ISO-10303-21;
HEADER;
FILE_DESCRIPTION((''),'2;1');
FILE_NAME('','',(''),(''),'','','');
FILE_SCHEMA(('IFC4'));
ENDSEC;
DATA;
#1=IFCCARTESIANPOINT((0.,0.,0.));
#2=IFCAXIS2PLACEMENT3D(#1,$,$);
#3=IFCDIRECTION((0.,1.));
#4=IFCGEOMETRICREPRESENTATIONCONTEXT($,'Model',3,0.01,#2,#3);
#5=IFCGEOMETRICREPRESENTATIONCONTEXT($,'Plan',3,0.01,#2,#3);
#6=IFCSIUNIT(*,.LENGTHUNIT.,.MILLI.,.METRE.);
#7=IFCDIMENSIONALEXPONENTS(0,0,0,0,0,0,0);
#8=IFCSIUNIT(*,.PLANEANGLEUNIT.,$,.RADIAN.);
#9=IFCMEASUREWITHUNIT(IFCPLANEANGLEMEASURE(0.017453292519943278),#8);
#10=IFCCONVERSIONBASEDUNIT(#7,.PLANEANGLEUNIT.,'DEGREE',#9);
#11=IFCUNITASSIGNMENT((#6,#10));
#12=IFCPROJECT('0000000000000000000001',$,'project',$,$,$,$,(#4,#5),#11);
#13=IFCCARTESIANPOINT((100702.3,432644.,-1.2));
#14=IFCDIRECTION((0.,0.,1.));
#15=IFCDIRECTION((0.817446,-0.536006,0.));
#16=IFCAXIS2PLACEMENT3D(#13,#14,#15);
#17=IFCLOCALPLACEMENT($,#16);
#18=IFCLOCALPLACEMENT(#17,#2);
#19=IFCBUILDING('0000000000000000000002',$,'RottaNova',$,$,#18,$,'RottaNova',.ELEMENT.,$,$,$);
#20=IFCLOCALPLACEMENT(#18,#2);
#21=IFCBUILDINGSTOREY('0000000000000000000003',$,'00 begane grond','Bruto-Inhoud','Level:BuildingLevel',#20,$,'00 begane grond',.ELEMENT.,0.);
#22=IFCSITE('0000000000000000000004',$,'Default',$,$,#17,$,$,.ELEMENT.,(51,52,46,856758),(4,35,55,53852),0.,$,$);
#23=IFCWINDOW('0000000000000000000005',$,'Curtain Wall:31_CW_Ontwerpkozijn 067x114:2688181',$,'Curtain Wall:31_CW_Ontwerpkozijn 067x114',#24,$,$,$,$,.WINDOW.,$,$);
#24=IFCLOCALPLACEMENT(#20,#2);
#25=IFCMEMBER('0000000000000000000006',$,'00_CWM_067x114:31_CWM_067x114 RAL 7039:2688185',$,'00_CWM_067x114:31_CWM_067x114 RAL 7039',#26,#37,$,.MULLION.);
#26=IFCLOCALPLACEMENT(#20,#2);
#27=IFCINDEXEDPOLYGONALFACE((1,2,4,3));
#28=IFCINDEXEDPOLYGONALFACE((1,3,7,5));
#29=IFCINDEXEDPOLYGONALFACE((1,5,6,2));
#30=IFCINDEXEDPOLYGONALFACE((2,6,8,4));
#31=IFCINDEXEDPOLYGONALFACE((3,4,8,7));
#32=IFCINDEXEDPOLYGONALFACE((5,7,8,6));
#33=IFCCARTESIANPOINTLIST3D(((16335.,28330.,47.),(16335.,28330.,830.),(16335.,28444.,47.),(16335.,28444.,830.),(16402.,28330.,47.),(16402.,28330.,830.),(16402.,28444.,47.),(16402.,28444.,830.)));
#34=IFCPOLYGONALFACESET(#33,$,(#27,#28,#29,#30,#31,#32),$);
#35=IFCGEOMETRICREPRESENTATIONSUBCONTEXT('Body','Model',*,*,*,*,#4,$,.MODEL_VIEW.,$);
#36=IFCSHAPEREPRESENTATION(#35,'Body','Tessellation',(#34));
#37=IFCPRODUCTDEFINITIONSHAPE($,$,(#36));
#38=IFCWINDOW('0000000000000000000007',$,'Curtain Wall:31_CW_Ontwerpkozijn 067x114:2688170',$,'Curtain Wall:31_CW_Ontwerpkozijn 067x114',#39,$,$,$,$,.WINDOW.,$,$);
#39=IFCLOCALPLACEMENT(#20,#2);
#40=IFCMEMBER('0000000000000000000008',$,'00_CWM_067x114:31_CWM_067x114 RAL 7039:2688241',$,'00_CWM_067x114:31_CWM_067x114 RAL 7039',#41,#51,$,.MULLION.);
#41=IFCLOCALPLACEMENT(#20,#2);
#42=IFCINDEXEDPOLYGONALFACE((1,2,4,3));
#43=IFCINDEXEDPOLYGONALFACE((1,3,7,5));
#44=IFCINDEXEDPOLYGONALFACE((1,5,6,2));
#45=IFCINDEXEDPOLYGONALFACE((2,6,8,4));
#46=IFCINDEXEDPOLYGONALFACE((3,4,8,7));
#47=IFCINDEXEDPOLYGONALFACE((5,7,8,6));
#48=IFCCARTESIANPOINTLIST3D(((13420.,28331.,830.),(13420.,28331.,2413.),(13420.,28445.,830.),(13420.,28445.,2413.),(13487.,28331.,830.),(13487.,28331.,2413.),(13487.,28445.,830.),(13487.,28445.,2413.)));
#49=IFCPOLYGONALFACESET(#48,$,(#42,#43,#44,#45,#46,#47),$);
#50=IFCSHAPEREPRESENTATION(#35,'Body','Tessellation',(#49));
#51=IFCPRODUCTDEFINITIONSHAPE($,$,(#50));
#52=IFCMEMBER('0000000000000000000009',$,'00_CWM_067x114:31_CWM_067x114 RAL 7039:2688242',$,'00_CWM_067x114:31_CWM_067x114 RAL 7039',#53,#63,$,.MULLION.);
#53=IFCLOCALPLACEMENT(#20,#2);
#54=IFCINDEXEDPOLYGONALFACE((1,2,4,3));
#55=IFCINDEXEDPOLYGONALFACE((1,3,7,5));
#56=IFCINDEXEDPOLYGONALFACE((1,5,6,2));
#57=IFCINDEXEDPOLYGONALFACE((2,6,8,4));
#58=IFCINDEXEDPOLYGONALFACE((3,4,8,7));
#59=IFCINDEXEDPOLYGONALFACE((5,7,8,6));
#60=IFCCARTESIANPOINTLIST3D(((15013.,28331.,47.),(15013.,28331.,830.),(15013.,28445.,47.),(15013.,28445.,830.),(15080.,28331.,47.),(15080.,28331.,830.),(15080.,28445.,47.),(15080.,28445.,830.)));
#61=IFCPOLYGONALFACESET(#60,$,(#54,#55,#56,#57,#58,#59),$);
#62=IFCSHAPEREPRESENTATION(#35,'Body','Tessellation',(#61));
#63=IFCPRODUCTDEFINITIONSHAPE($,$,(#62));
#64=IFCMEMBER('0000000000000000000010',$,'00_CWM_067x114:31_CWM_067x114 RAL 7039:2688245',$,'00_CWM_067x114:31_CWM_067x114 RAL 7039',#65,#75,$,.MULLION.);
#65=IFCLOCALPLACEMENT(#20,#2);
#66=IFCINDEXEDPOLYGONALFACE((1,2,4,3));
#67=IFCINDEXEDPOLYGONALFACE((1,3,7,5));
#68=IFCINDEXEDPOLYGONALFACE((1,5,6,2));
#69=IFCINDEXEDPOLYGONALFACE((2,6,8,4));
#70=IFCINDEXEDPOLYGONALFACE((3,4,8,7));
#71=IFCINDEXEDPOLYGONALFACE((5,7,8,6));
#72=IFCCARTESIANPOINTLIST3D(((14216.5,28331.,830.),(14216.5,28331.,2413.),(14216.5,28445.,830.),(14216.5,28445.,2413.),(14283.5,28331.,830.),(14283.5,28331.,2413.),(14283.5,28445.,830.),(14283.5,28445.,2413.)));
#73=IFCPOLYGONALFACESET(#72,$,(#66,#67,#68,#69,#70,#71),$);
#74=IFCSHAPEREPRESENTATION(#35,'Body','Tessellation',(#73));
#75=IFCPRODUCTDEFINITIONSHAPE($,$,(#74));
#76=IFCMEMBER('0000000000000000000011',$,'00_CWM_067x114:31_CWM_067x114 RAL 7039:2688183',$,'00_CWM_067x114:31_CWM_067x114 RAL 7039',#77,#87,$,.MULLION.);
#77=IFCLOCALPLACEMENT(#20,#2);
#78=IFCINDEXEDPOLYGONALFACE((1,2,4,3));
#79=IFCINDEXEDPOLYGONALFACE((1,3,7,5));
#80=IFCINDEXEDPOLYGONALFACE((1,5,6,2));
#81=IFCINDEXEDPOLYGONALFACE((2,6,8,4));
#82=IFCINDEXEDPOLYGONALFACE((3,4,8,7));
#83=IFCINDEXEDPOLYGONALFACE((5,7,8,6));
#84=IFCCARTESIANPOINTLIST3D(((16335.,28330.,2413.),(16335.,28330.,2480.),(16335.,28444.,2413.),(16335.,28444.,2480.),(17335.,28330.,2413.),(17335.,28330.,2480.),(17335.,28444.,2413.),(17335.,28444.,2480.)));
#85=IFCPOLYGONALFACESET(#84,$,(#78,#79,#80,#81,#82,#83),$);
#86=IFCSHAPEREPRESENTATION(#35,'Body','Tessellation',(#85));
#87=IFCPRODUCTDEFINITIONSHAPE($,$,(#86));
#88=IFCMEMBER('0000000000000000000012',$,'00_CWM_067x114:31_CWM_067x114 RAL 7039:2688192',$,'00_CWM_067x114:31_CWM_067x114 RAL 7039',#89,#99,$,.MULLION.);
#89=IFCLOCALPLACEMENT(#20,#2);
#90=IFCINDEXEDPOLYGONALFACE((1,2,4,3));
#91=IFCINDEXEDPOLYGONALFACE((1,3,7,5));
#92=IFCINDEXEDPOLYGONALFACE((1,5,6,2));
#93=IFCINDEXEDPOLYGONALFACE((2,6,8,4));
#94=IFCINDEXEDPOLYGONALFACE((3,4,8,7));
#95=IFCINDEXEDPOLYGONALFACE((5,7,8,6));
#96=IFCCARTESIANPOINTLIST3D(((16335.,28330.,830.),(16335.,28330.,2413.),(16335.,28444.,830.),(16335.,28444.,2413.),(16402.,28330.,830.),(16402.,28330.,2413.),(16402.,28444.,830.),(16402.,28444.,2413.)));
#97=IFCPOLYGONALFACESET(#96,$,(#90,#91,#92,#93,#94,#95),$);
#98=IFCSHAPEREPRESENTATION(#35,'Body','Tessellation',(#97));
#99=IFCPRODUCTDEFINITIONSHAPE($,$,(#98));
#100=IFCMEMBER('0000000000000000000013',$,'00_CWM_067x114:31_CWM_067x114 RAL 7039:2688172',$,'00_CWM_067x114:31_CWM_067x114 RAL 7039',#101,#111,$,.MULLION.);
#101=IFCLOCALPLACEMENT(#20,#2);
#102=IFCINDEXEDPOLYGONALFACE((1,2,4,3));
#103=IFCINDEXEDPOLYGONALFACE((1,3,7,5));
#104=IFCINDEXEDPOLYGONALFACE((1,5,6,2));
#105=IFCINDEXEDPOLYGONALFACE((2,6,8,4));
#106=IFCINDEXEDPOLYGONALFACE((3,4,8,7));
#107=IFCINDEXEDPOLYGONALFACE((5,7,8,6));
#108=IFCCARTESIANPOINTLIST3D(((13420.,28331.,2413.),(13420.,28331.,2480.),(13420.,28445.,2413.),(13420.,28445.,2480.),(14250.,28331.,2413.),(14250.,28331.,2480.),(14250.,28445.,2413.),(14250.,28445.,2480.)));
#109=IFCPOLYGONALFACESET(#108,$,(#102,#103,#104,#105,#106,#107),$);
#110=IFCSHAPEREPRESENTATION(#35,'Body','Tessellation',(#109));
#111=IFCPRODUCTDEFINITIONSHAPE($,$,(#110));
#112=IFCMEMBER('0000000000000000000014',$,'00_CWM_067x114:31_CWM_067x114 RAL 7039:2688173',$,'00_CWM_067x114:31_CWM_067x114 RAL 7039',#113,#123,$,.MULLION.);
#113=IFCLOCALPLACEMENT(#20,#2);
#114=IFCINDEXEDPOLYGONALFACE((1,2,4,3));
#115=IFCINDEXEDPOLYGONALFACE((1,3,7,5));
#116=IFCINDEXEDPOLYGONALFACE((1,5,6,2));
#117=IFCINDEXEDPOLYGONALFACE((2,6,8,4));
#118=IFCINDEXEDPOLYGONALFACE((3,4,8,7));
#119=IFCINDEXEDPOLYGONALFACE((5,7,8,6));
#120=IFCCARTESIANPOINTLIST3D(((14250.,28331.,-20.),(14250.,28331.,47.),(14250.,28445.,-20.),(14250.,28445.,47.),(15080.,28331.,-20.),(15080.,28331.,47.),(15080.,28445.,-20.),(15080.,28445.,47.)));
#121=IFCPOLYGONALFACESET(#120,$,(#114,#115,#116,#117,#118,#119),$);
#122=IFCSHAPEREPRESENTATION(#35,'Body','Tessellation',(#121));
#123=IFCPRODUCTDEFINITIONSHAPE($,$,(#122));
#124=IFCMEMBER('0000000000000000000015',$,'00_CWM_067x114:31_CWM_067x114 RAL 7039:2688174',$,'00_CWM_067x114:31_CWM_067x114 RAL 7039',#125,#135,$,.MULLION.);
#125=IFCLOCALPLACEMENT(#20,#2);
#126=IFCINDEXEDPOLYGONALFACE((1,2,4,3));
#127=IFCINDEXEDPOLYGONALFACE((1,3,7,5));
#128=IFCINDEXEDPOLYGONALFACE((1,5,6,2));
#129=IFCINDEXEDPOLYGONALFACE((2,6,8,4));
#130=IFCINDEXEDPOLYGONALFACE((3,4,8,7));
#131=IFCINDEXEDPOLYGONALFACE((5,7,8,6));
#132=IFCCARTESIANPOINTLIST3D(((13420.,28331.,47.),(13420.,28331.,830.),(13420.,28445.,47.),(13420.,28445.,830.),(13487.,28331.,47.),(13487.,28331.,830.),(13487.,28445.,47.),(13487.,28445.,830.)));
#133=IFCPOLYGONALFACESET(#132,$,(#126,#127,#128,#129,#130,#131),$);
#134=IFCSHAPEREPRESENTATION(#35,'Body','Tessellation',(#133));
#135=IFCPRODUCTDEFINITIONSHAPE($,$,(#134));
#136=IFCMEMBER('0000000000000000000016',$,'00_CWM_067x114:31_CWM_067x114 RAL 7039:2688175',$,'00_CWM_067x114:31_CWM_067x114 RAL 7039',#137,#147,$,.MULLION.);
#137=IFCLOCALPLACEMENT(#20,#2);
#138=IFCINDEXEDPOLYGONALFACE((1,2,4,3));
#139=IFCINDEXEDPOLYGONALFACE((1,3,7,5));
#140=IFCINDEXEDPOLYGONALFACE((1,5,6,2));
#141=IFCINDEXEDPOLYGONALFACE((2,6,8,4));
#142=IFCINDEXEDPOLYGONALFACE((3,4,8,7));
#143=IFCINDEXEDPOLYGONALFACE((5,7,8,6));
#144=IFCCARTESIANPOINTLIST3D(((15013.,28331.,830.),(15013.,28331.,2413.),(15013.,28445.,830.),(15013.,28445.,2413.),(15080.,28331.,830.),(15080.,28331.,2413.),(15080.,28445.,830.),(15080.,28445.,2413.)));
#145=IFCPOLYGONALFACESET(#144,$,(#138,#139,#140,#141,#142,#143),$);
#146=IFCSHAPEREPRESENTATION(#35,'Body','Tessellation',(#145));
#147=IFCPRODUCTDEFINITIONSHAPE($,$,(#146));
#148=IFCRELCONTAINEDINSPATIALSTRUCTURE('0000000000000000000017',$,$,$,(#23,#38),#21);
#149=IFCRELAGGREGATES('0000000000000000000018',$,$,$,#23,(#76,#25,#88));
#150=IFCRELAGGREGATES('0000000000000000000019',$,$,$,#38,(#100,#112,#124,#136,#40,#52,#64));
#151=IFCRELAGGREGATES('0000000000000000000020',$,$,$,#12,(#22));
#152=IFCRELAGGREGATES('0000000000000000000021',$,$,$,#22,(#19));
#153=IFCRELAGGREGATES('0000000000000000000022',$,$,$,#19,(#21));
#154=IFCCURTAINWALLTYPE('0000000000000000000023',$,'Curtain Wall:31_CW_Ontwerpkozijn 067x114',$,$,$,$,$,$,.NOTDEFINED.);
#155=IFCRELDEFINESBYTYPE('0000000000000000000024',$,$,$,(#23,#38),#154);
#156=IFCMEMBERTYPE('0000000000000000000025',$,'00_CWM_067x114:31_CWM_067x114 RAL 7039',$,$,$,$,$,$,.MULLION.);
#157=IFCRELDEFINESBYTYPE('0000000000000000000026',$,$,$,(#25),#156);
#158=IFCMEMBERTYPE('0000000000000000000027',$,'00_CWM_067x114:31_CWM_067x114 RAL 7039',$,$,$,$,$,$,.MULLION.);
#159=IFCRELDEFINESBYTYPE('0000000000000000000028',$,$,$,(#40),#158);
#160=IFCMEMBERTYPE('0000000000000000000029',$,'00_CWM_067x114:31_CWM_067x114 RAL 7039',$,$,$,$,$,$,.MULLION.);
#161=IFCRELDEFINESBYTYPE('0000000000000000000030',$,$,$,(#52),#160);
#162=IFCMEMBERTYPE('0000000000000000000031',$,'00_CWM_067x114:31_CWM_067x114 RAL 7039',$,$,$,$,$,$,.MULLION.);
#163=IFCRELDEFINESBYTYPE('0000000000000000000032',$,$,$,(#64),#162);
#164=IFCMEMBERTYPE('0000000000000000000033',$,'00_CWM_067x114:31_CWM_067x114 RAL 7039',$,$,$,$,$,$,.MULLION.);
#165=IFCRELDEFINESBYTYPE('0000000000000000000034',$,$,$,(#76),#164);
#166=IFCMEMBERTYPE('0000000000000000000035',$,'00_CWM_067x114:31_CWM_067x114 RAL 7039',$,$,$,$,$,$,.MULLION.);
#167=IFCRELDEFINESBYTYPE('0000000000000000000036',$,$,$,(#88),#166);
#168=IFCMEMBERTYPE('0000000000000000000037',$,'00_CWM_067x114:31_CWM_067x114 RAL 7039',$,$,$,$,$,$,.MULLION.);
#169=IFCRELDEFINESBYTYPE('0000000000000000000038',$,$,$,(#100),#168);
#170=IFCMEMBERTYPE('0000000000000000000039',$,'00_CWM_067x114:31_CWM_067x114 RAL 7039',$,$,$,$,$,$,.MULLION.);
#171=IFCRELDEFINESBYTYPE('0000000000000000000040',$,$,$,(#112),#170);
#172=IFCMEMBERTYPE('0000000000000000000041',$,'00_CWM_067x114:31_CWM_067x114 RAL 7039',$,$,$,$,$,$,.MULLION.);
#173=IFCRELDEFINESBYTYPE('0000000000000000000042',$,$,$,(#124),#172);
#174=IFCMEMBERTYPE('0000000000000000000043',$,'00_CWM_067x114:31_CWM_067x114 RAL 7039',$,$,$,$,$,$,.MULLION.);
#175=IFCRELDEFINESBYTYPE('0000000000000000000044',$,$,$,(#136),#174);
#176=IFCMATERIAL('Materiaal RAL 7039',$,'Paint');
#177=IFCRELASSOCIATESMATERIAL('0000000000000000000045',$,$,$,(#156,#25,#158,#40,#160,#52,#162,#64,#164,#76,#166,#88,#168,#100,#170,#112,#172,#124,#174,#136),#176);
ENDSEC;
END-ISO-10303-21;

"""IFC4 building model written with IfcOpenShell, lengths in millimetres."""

from ifc_helpers import new_model, entity, si_unit, converted_unit, direction, frame, origin, place, context, subcontext, project, spatial, indexed_curve, outline, extrude, source, transform, mapped, material, type_object, type_shapes, element, aggregate, save


model = new_model("IFC4")

# Units and contexts
model_context = context("Model", 3, precision=0.01, world=origin(), true_north=direction((0.0, 1.0)))
plan_context = context("Plan", 3, precision=0.01, world=origin(), true_north=direction((0.0, 1.0)))
body_context = subcontext(model_context, "Body", "Model", "MODEL_VIEW")
ifc_project = project(units=[si_unit("LENGTHUNIT", "METRE", prefix="MILLI"), converted_unit("PLANEANGLEUNIT", "DEGREE", entity("IfcPlaneAngleMeasure", 0.017453292519943278), si_unit("PLANEANGLEUNIT", "RADIAN"), dimensions=[0, 0, 0, 0, 0, 0, 0])], contexts=[model_context, plan_context])

# Site, building, storey
site_placement = place(None, frame((100702.3, 432644.0, -1.2), z_axis=(0.0, 0.0, 1.0), x_axis=(0.817446, -0.536006, 0.0)))
site = spatial("IfcSite", under=ifc_project, at=site_placement, Name="Default", CompositionType="ELEMENT", RefLatitude=(51, 52, 46, 856758), RefLongitude=(4, 35, 55, 53852), RefElevation=0.0)
building_placement = place(site_placement, origin())
building = spatial("IfcBuilding", under=site, at=building_placement, Name="RottaNova", LongName="RottaNova", CompositionType="ELEMENT")
storey_placement = place(building_placement, origin())
storey = spatial("IfcBuildingStorey", under=building, at=storey_placement, Name="00 begane grond", Description="Bruto-Inhoud", ObjectType="Level:BuildingLevel", LongName="00 begane grond", CompositionType="ELEMENT", Elevation=0.0)

# Window, member
curtain_wall_type = type_object("IfcCurtainWallType", Name="Curtain Wall:31_CW_Ontwerpkozijn 067x114", PredefinedType="NOTDEFINED")
window_1_placement = place(storey_placement, origin())
window_1 = element("IfcWindow", 1, at=window_1_placement, inside=storey, type_object=curtain_wall_type, Name="Curtain Wall:31_CW_Ontwerpkozijn 067x114:2688181", ObjectType="Curtain Wall:31_CW_Ontwerpkozijn 067x114", PredefinedType="WINDOW")
ifc_material_1 = material(Name="Materiaal RAL 7039", Category="Paint")
member_type_1 = type_object("IfcMemberType", Name="00_CWM_067x114:31_CWM_067x114 RAL 7039", PredefinedType="MULLION", material=ifc_material_1)
shared_shape_1 = source(origin(), body_context, "Body", "SweptSolid", [
    extrude(outline(indexed_curve([(-33.5, -57.0), (33.5, -57.0), (33.5, 57.0), (-33.5, 57.0), (-33.5, -57.0)], self_intersect=False)), frame((-33.5, 57.0, -783.0), z_axis=(0.0, 0.0, 1.0), x_axis=(-1.0, 0.0, 0.0)), (0.0, 0.0, 1.0), 783.0),
])
type_shapes(member_type_1, [shared_shape_1])
member_1_placement = place(window_1_placement, frame((16335.0, 28330.0, 47.0), z_axis=(0.0, 0.0, -1.0), x_axis=(-1.0, 0.0, 0.0)))
member_1 = element("IfcMember", 2, at=member_1_placement, type_object=member_type_1, material=ifc_material_1, Name="00_CWM_067x114:31_CWM_067x114 RAL 7039:2688185", ObjectType="00_CWM_067x114:31_CWM_067x114 RAL 7039", PredefinedType="MULLION", context=body_context, shape_type="MappedRepresentation", body=[
    mapped(shared_shape_1, transform((0.0, 0.0, 0.0), scale=1.0)),
])

# Window, members
window_2_placement = place(storey_placement, origin())
window_2 = element("IfcWindow", 3, at=window_2_placement, inside=storey, type_object=curtain_wall_type, Name="Curtain Wall:31_CW_Ontwerpkozijn 067x114:2688170", ObjectType="Curtain Wall:31_CW_Ontwerpkozijn 067x114", PredefinedType="WINDOW")
member_type_2 = type_object("IfcMemberType", Name="00_CWM_067x114:31_CWM_067x114 RAL 7039", PredefinedType="MULLION", material=ifc_material_1)
shared_shape_2 = source(origin(), body_context, "Body", "SweptSolid", [
    extrude(outline(indexed_curve([(-33.5, -57.0), (33.5, -57.0), (33.5, 57.0), (-33.5, 57.0), (-33.5, -57.0)], self_intersect=False)), frame((-33.5, 57.0, -1583.0), z_axis=(0.0, 0.0, 1.0), x_axis=(-1.0, 0.0, 0.0)), (0.0, 0.0, 1.0), 1583.0),
])
type_shapes(member_type_2, [shared_shape_2])
member_2_placement = place(window_2_placement, frame((13420.0, 28331.0, 830.0), z_axis=(0.0, 0.0, -1.0), x_axis=(-1.0, 0.0, 0.0)))
member_2 = element("IfcMember", 4, at=member_2_placement, type_object=member_type_2, material=ifc_material_1, Name="00_CWM_067x114:31_CWM_067x114 RAL 7039:2688241", ObjectType="00_CWM_067x114:31_CWM_067x114 RAL 7039", PredefinedType="MULLION", context=body_context, shape_type="MappedRepresentation", body=[
    mapped(shared_shape_2, transform((0.0, 0.0, 0.0), scale=1.0)),
])
member_type_3 = type_object("IfcMemberType", Name="00_CWM_067x114:31_CWM_067x114 RAL 7039", PredefinedType="MULLION", material=ifc_material_1)
shared_shape_3 = source(origin(), body_context, "Body", "SweptSolid", [
    extrude(outline(indexed_curve([(-33.5, -57.0), (33.5, -57.0), (33.5, 57.0), (-33.5, 57.0), (-33.5, -57.0)], self_intersect=False)), frame((-33.5, 57.0, -783.0), z_axis=(0.0, 0.0, 1.0), x_axis=(-1.0, 0.0, 0.0)), (0.0, 0.0, 1.0), 783.0),
])
type_shapes(member_type_3, [shared_shape_3])
member_3_placement = place(window_2_placement, frame((15080.0, 28331.0, 830.0)))
member_3 = element("IfcMember", 5, at=member_3_placement, type_object=member_type_3, material=ifc_material_1, Name="00_CWM_067x114:31_CWM_067x114 RAL 7039:2688242", ObjectType="00_CWM_067x114:31_CWM_067x114 RAL 7039", PredefinedType="MULLION", context=body_context, shape_type="MappedRepresentation", body=[
    mapped(shared_shape_3, transform((0.0, 0.0, 0.0), scale=1.0)),
])
member_type_4 = type_object("IfcMemberType", Name="00_CWM_067x114:31_CWM_067x114 RAL 7039", PredefinedType="MULLION", material=ifc_material_1)
shared_shape_4 = source(origin(), body_context, "Body", "SweptSolid", [
    extrude(outline(indexed_curve([(-33.5, -57.0), (33.5, -57.0), (33.5, 57.0), (-33.5, 57.0), (-33.5, -57.0)], self_intersect=False)), frame((0.0, 57.0, -1583.0), z_axis=(0.0, 0.0, 1.0), x_axis=(-1.0, 0.0, 0.0)), (0.0, 0.0, 1.0), 1583.0),
])
type_shapes(member_type_4, [shared_shape_4])
member_4_placement = place(window_2_placement, frame((14250.0, 28331.0, 830.0), z_axis=(0.0, 0.0, -1.0), x_axis=(-1.0, 0.0, 0.0)))
member_4 = element("IfcMember", 6, at=member_4_placement, type_object=member_type_4, material=ifc_material_1, Name="00_CWM_067x114:31_CWM_067x114 RAL 7039:2688245", ObjectType="00_CWM_067x114:31_CWM_067x114 RAL 7039", PredefinedType="MULLION", context=body_context, shape_type="MappedRepresentation", body=[
    mapped(shared_shape_4, transform((0.0, 0.0, 0.0), scale=1.0)),
])

# Members
member_type_5 = type_object("IfcMemberType", Name="00_CWM_067x114:31_CWM_067x114 RAL 7039", PredefinedType="MULLION", material=ifc_material_1)
shared_shape_5 = source(origin(), body_context, "Body", "SweptSolid", [
    extrude(outline(indexed_curve([(-33.5, -57.0), (33.5, -57.0), (33.5, 57.0), (-33.5, 57.0), (-33.5, -57.0)], self_intersect=False)), frame((-33.5, 57.0, -1000.0), z_axis=(0.0, 0.0, 1.0), x_axis=(-1.0, 0.0, 0.0)), (0.0, 0.0, 1.0), 1000.0),
])
type_shapes(member_type_5, [shared_shape_5])
member_5_placement = place(window_1_placement, frame((16335.0, 28330.0, 2480.0), z_axis=(-1.0, 0.0, 0.0), x_axis=(0.0, 0.0, 1.0)))
member_5 = element("IfcMember", 7, at=member_5_placement, type_object=member_type_5, material=ifc_material_1, Name="00_CWM_067x114:31_CWM_067x114 RAL 7039:2688183", ObjectType="00_CWM_067x114:31_CWM_067x114 RAL 7039", PredefinedType="MULLION", context=body_context, shape_type="MappedRepresentation", body=[
    mapped(shared_shape_5, transform((0.0, 0.0, 0.0), scale=1.0)),
])
member_type_6 = type_object("IfcMemberType", Name="00_CWM_067x114:31_CWM_067x114 RAL 7039", PredefinedType="MULLION", material=ifc_material_1)
shared_shape_6 = source(origin(), body_context, "Body", "SweptSolid", [
    extrude(outline(indexed_curve([(-33.5, -57.0), (33.5, -57.0), (33.5, 57.0), (-33.5, 57.0), (-33.5, -57.0)], self_intersect=False)), frame((-33.5, 57.0, -1583.0), z_axis=(0.0, 0.0, 1.0), x_axis=(-1.0, 0.0, 0.0)), (0.0, 0.0, 1.0), 1583.0),
])
type_shapes(member_type_6, [shared_shape_6])
member_6_placement = place(window_1_placement, frame((16335.0, 28330.0, 830.0), z_axis=(0.0, 0.0, -1.0), x_axis=(-1.0, 0.0, 0.0)))
member_6 = element("IfcMember", 8, at=member_6_placement, type_object=member_type_6, material=ifc_material_1, Name="00_CWM_067x114:31_CWM_067x114 RAL 7039:2688192", ObjectType="00_CWM_067x114:31_CWM_067x114 RAL 7039", PredefinedType="MULLION", context=body_context, shape_type="MappedRepresentation", body=[
    mapped(shared_shape_6, transform((0.0, 0.0, 0.0), scale=1.0)),
])
aggregate(window_1, [member_5, member_1, member_6])
member_type_7 = type_object("IfcMemberType", Name="00_CWM_067x114:31_CWM_067x114 RAL 7039", PredefinedType="MULLION", material=ifc_material_1)
shared_shape_7 = source(origin(), body_context, "Body", "SweptSolid", [
    extrude(outline(indexed_curve([(-33.5, -57.0), (33.5, -57.0), (33.5, 57.0), (-33.5, 57.0), (-33.5, -57.0)], self_intersect=False)), frame((-33.5, 57.0, -830.0), z_axis=(0.0, 0.0, 1.0), x_axis=(-1.0, 0.0, 0.0)), (0.0, 0.0, 1.0), 830.0),
])
type_shapes(member_type_7, [shared_shape_7])
member_7_placement = place(window_2_placement, frame((13420.0, 28331.0, 2480.0), z_axis=(-1.0, 0.0, 0.0), x_axis=(0.0, 0.0, 1.0)))
member_7 = element("IfcMember", 9, at=member_7_placement, type_object=member_type_7, material=ifc_material_1, Name="00_CWM_067x114:31_CWM_067x114 RAL 7039:2688172", ObjectType="00_CWM_067x114:31_CWM_067x114 RAL 7039", PredefinedType="MULLION", context=body_context, shape_type="MappedRepresentation", body=[
    mapped(shared_shape_7, transform((0.0, 0.0, 0.0), scale=1.0)),
])
member_type_8 = type_object("IfcMemberType", Name="00_CWM_067x114:31_CWM_067x114 RAL 7039", PredefinedType="MULLION", material=ifc_material_1)
shared_shape_8 = source(origin(), body_context, "Body", "SweptSolid", [
    extrude(outline(indexed_curve([(-33.5, -57.0), (33.5, -57.0), (33.5, 57.0), (-33.5, 57.0), (-33.5, -57.0)], self_intersect=False)), frame((-33.5, 57.0, -830.0), z_axis=(0.0, 0.0, 1.0), x_axis=(-1.0, 0.0, 0.0)), (0.0, 0.0, 1.0), 830.0),
])
type_shapes(member_type_8, [shared_shape_8])
member_8_placement = place(window_2_placement, frame((15080.0, 28331.0, -20.0), z_axis=(1.0, 0.0, 0.0), x_axis=(0.0, 0.0, -1.0)))
member_8 = element("IfcMember", 10, at=member_8_placement, type_object=member_type_8, material=ifc_material_1, Name="00_CWM_067x114:31_CWM_067x114 RAL 7039:2688173", ObjectType="00_CWM_067x114:31_CWM_067x114 RAL 7039", PredefinedType="MULLION", context=body_context, shape_type="MappedRepresentation", body=[
    mapped(shared_shape_8, transform((0.0, 0.0, 0.0), scale=1.0)),
])
member_type_9 = type_object("IfcMemberType", Name="00_CWM_067x114:31_CWM_067x114 RAL 7039", PredefinedType="MULLION", material=ifc_material_1)
shared_shape_9 = source(origin(), body_context, "Body", "SweptSolid", [
    extrude(outline(indexed_curve([(-33.5, -57.0), (33.5, -57.0), (33.5, 57.0), (-33.5, 57.0), (-33.5, -57.0)], self_intersect=False)), frame((-33.5, 57.0, -783.0), z_axis=(0.0, 0.0, 1.0), x_axis=(-1.0, 0.0, 0.0)), (0.0, 0.0, 1.0), 783.0),
])
type_shapes(member_type_9, [shared_shape_9])
member_9_placement = place(window_2_placement, frame((13420.0, 28331.0, 47.0), z_axis=(0.0, 0.0, -1.0), x_axis=(-1.0, 0.0, 0.0)))
member_9 = element("IfcMember", 11, at=member_9_placement, type_object=member_type_9, material=ifc_material_1, Name="00_CWM_067x114:31_CWM_067x114 RAL 7039:2688174", ObjectType="00_CWM_067x114:31_CWM_067x114 RAL 7039", PredefinedType="MULLION", context=body_context, shape_type="MappedRepresentation", body=[
    mapped(shared_shape_9, transform((0.0, 0.0, 0.0), scale=1.0)),
])
member_type_10 = type_object("IfcMemberType", Name="00_CWM_067x114:31_CWM_067x114 RAL 7039", PredefinedType="MULLION", material=ifc_material_1)
shared_shape_10 = source(origin(), body_context, "Body", "SweptSolid", [
    extrude(outline(indexed_curve([(-33.5, -57.0), (33.5, -57.0), (33.5, 57.0), (-33.5, 57.0), (-33.5, -57.0)], self_intersect=False)), frame((-33.5, 57.0, -1583.0), z_axis=(0.0, 0.0, 1.0), x_axis=(-1.0, 0.0, 0.0)), (0.0, 0.0, 1.0), 1583.0),
])
type_shapes(member_type_10, [shared_shape_10])
member_10_placement = place(window_2_placement, frame((15080.0, 28331.0, 2413.0)))
member_10 = element("IfcMember", 12, at=member_10_placement, type_object=member_type_10, material=ifc_material_1, Name="00_CWM_067x114:31_CWM_067x114 RAL 7039:2688175", ObjectType="00_CWM_067x114:31_CWM_067x114 RAL 7039", PredefinedType="MULLION", context=body_context, shape_type="MappedRepresentation", body=[
    mapped(shared_shape_10, transform((0.0, 0.0, 0.0), scale=1.0)),
])

aggregate(window_2, [member_7, member_8, member_9, member_10, member_2, member_3, member_4])

save(model, "model.ifc")
